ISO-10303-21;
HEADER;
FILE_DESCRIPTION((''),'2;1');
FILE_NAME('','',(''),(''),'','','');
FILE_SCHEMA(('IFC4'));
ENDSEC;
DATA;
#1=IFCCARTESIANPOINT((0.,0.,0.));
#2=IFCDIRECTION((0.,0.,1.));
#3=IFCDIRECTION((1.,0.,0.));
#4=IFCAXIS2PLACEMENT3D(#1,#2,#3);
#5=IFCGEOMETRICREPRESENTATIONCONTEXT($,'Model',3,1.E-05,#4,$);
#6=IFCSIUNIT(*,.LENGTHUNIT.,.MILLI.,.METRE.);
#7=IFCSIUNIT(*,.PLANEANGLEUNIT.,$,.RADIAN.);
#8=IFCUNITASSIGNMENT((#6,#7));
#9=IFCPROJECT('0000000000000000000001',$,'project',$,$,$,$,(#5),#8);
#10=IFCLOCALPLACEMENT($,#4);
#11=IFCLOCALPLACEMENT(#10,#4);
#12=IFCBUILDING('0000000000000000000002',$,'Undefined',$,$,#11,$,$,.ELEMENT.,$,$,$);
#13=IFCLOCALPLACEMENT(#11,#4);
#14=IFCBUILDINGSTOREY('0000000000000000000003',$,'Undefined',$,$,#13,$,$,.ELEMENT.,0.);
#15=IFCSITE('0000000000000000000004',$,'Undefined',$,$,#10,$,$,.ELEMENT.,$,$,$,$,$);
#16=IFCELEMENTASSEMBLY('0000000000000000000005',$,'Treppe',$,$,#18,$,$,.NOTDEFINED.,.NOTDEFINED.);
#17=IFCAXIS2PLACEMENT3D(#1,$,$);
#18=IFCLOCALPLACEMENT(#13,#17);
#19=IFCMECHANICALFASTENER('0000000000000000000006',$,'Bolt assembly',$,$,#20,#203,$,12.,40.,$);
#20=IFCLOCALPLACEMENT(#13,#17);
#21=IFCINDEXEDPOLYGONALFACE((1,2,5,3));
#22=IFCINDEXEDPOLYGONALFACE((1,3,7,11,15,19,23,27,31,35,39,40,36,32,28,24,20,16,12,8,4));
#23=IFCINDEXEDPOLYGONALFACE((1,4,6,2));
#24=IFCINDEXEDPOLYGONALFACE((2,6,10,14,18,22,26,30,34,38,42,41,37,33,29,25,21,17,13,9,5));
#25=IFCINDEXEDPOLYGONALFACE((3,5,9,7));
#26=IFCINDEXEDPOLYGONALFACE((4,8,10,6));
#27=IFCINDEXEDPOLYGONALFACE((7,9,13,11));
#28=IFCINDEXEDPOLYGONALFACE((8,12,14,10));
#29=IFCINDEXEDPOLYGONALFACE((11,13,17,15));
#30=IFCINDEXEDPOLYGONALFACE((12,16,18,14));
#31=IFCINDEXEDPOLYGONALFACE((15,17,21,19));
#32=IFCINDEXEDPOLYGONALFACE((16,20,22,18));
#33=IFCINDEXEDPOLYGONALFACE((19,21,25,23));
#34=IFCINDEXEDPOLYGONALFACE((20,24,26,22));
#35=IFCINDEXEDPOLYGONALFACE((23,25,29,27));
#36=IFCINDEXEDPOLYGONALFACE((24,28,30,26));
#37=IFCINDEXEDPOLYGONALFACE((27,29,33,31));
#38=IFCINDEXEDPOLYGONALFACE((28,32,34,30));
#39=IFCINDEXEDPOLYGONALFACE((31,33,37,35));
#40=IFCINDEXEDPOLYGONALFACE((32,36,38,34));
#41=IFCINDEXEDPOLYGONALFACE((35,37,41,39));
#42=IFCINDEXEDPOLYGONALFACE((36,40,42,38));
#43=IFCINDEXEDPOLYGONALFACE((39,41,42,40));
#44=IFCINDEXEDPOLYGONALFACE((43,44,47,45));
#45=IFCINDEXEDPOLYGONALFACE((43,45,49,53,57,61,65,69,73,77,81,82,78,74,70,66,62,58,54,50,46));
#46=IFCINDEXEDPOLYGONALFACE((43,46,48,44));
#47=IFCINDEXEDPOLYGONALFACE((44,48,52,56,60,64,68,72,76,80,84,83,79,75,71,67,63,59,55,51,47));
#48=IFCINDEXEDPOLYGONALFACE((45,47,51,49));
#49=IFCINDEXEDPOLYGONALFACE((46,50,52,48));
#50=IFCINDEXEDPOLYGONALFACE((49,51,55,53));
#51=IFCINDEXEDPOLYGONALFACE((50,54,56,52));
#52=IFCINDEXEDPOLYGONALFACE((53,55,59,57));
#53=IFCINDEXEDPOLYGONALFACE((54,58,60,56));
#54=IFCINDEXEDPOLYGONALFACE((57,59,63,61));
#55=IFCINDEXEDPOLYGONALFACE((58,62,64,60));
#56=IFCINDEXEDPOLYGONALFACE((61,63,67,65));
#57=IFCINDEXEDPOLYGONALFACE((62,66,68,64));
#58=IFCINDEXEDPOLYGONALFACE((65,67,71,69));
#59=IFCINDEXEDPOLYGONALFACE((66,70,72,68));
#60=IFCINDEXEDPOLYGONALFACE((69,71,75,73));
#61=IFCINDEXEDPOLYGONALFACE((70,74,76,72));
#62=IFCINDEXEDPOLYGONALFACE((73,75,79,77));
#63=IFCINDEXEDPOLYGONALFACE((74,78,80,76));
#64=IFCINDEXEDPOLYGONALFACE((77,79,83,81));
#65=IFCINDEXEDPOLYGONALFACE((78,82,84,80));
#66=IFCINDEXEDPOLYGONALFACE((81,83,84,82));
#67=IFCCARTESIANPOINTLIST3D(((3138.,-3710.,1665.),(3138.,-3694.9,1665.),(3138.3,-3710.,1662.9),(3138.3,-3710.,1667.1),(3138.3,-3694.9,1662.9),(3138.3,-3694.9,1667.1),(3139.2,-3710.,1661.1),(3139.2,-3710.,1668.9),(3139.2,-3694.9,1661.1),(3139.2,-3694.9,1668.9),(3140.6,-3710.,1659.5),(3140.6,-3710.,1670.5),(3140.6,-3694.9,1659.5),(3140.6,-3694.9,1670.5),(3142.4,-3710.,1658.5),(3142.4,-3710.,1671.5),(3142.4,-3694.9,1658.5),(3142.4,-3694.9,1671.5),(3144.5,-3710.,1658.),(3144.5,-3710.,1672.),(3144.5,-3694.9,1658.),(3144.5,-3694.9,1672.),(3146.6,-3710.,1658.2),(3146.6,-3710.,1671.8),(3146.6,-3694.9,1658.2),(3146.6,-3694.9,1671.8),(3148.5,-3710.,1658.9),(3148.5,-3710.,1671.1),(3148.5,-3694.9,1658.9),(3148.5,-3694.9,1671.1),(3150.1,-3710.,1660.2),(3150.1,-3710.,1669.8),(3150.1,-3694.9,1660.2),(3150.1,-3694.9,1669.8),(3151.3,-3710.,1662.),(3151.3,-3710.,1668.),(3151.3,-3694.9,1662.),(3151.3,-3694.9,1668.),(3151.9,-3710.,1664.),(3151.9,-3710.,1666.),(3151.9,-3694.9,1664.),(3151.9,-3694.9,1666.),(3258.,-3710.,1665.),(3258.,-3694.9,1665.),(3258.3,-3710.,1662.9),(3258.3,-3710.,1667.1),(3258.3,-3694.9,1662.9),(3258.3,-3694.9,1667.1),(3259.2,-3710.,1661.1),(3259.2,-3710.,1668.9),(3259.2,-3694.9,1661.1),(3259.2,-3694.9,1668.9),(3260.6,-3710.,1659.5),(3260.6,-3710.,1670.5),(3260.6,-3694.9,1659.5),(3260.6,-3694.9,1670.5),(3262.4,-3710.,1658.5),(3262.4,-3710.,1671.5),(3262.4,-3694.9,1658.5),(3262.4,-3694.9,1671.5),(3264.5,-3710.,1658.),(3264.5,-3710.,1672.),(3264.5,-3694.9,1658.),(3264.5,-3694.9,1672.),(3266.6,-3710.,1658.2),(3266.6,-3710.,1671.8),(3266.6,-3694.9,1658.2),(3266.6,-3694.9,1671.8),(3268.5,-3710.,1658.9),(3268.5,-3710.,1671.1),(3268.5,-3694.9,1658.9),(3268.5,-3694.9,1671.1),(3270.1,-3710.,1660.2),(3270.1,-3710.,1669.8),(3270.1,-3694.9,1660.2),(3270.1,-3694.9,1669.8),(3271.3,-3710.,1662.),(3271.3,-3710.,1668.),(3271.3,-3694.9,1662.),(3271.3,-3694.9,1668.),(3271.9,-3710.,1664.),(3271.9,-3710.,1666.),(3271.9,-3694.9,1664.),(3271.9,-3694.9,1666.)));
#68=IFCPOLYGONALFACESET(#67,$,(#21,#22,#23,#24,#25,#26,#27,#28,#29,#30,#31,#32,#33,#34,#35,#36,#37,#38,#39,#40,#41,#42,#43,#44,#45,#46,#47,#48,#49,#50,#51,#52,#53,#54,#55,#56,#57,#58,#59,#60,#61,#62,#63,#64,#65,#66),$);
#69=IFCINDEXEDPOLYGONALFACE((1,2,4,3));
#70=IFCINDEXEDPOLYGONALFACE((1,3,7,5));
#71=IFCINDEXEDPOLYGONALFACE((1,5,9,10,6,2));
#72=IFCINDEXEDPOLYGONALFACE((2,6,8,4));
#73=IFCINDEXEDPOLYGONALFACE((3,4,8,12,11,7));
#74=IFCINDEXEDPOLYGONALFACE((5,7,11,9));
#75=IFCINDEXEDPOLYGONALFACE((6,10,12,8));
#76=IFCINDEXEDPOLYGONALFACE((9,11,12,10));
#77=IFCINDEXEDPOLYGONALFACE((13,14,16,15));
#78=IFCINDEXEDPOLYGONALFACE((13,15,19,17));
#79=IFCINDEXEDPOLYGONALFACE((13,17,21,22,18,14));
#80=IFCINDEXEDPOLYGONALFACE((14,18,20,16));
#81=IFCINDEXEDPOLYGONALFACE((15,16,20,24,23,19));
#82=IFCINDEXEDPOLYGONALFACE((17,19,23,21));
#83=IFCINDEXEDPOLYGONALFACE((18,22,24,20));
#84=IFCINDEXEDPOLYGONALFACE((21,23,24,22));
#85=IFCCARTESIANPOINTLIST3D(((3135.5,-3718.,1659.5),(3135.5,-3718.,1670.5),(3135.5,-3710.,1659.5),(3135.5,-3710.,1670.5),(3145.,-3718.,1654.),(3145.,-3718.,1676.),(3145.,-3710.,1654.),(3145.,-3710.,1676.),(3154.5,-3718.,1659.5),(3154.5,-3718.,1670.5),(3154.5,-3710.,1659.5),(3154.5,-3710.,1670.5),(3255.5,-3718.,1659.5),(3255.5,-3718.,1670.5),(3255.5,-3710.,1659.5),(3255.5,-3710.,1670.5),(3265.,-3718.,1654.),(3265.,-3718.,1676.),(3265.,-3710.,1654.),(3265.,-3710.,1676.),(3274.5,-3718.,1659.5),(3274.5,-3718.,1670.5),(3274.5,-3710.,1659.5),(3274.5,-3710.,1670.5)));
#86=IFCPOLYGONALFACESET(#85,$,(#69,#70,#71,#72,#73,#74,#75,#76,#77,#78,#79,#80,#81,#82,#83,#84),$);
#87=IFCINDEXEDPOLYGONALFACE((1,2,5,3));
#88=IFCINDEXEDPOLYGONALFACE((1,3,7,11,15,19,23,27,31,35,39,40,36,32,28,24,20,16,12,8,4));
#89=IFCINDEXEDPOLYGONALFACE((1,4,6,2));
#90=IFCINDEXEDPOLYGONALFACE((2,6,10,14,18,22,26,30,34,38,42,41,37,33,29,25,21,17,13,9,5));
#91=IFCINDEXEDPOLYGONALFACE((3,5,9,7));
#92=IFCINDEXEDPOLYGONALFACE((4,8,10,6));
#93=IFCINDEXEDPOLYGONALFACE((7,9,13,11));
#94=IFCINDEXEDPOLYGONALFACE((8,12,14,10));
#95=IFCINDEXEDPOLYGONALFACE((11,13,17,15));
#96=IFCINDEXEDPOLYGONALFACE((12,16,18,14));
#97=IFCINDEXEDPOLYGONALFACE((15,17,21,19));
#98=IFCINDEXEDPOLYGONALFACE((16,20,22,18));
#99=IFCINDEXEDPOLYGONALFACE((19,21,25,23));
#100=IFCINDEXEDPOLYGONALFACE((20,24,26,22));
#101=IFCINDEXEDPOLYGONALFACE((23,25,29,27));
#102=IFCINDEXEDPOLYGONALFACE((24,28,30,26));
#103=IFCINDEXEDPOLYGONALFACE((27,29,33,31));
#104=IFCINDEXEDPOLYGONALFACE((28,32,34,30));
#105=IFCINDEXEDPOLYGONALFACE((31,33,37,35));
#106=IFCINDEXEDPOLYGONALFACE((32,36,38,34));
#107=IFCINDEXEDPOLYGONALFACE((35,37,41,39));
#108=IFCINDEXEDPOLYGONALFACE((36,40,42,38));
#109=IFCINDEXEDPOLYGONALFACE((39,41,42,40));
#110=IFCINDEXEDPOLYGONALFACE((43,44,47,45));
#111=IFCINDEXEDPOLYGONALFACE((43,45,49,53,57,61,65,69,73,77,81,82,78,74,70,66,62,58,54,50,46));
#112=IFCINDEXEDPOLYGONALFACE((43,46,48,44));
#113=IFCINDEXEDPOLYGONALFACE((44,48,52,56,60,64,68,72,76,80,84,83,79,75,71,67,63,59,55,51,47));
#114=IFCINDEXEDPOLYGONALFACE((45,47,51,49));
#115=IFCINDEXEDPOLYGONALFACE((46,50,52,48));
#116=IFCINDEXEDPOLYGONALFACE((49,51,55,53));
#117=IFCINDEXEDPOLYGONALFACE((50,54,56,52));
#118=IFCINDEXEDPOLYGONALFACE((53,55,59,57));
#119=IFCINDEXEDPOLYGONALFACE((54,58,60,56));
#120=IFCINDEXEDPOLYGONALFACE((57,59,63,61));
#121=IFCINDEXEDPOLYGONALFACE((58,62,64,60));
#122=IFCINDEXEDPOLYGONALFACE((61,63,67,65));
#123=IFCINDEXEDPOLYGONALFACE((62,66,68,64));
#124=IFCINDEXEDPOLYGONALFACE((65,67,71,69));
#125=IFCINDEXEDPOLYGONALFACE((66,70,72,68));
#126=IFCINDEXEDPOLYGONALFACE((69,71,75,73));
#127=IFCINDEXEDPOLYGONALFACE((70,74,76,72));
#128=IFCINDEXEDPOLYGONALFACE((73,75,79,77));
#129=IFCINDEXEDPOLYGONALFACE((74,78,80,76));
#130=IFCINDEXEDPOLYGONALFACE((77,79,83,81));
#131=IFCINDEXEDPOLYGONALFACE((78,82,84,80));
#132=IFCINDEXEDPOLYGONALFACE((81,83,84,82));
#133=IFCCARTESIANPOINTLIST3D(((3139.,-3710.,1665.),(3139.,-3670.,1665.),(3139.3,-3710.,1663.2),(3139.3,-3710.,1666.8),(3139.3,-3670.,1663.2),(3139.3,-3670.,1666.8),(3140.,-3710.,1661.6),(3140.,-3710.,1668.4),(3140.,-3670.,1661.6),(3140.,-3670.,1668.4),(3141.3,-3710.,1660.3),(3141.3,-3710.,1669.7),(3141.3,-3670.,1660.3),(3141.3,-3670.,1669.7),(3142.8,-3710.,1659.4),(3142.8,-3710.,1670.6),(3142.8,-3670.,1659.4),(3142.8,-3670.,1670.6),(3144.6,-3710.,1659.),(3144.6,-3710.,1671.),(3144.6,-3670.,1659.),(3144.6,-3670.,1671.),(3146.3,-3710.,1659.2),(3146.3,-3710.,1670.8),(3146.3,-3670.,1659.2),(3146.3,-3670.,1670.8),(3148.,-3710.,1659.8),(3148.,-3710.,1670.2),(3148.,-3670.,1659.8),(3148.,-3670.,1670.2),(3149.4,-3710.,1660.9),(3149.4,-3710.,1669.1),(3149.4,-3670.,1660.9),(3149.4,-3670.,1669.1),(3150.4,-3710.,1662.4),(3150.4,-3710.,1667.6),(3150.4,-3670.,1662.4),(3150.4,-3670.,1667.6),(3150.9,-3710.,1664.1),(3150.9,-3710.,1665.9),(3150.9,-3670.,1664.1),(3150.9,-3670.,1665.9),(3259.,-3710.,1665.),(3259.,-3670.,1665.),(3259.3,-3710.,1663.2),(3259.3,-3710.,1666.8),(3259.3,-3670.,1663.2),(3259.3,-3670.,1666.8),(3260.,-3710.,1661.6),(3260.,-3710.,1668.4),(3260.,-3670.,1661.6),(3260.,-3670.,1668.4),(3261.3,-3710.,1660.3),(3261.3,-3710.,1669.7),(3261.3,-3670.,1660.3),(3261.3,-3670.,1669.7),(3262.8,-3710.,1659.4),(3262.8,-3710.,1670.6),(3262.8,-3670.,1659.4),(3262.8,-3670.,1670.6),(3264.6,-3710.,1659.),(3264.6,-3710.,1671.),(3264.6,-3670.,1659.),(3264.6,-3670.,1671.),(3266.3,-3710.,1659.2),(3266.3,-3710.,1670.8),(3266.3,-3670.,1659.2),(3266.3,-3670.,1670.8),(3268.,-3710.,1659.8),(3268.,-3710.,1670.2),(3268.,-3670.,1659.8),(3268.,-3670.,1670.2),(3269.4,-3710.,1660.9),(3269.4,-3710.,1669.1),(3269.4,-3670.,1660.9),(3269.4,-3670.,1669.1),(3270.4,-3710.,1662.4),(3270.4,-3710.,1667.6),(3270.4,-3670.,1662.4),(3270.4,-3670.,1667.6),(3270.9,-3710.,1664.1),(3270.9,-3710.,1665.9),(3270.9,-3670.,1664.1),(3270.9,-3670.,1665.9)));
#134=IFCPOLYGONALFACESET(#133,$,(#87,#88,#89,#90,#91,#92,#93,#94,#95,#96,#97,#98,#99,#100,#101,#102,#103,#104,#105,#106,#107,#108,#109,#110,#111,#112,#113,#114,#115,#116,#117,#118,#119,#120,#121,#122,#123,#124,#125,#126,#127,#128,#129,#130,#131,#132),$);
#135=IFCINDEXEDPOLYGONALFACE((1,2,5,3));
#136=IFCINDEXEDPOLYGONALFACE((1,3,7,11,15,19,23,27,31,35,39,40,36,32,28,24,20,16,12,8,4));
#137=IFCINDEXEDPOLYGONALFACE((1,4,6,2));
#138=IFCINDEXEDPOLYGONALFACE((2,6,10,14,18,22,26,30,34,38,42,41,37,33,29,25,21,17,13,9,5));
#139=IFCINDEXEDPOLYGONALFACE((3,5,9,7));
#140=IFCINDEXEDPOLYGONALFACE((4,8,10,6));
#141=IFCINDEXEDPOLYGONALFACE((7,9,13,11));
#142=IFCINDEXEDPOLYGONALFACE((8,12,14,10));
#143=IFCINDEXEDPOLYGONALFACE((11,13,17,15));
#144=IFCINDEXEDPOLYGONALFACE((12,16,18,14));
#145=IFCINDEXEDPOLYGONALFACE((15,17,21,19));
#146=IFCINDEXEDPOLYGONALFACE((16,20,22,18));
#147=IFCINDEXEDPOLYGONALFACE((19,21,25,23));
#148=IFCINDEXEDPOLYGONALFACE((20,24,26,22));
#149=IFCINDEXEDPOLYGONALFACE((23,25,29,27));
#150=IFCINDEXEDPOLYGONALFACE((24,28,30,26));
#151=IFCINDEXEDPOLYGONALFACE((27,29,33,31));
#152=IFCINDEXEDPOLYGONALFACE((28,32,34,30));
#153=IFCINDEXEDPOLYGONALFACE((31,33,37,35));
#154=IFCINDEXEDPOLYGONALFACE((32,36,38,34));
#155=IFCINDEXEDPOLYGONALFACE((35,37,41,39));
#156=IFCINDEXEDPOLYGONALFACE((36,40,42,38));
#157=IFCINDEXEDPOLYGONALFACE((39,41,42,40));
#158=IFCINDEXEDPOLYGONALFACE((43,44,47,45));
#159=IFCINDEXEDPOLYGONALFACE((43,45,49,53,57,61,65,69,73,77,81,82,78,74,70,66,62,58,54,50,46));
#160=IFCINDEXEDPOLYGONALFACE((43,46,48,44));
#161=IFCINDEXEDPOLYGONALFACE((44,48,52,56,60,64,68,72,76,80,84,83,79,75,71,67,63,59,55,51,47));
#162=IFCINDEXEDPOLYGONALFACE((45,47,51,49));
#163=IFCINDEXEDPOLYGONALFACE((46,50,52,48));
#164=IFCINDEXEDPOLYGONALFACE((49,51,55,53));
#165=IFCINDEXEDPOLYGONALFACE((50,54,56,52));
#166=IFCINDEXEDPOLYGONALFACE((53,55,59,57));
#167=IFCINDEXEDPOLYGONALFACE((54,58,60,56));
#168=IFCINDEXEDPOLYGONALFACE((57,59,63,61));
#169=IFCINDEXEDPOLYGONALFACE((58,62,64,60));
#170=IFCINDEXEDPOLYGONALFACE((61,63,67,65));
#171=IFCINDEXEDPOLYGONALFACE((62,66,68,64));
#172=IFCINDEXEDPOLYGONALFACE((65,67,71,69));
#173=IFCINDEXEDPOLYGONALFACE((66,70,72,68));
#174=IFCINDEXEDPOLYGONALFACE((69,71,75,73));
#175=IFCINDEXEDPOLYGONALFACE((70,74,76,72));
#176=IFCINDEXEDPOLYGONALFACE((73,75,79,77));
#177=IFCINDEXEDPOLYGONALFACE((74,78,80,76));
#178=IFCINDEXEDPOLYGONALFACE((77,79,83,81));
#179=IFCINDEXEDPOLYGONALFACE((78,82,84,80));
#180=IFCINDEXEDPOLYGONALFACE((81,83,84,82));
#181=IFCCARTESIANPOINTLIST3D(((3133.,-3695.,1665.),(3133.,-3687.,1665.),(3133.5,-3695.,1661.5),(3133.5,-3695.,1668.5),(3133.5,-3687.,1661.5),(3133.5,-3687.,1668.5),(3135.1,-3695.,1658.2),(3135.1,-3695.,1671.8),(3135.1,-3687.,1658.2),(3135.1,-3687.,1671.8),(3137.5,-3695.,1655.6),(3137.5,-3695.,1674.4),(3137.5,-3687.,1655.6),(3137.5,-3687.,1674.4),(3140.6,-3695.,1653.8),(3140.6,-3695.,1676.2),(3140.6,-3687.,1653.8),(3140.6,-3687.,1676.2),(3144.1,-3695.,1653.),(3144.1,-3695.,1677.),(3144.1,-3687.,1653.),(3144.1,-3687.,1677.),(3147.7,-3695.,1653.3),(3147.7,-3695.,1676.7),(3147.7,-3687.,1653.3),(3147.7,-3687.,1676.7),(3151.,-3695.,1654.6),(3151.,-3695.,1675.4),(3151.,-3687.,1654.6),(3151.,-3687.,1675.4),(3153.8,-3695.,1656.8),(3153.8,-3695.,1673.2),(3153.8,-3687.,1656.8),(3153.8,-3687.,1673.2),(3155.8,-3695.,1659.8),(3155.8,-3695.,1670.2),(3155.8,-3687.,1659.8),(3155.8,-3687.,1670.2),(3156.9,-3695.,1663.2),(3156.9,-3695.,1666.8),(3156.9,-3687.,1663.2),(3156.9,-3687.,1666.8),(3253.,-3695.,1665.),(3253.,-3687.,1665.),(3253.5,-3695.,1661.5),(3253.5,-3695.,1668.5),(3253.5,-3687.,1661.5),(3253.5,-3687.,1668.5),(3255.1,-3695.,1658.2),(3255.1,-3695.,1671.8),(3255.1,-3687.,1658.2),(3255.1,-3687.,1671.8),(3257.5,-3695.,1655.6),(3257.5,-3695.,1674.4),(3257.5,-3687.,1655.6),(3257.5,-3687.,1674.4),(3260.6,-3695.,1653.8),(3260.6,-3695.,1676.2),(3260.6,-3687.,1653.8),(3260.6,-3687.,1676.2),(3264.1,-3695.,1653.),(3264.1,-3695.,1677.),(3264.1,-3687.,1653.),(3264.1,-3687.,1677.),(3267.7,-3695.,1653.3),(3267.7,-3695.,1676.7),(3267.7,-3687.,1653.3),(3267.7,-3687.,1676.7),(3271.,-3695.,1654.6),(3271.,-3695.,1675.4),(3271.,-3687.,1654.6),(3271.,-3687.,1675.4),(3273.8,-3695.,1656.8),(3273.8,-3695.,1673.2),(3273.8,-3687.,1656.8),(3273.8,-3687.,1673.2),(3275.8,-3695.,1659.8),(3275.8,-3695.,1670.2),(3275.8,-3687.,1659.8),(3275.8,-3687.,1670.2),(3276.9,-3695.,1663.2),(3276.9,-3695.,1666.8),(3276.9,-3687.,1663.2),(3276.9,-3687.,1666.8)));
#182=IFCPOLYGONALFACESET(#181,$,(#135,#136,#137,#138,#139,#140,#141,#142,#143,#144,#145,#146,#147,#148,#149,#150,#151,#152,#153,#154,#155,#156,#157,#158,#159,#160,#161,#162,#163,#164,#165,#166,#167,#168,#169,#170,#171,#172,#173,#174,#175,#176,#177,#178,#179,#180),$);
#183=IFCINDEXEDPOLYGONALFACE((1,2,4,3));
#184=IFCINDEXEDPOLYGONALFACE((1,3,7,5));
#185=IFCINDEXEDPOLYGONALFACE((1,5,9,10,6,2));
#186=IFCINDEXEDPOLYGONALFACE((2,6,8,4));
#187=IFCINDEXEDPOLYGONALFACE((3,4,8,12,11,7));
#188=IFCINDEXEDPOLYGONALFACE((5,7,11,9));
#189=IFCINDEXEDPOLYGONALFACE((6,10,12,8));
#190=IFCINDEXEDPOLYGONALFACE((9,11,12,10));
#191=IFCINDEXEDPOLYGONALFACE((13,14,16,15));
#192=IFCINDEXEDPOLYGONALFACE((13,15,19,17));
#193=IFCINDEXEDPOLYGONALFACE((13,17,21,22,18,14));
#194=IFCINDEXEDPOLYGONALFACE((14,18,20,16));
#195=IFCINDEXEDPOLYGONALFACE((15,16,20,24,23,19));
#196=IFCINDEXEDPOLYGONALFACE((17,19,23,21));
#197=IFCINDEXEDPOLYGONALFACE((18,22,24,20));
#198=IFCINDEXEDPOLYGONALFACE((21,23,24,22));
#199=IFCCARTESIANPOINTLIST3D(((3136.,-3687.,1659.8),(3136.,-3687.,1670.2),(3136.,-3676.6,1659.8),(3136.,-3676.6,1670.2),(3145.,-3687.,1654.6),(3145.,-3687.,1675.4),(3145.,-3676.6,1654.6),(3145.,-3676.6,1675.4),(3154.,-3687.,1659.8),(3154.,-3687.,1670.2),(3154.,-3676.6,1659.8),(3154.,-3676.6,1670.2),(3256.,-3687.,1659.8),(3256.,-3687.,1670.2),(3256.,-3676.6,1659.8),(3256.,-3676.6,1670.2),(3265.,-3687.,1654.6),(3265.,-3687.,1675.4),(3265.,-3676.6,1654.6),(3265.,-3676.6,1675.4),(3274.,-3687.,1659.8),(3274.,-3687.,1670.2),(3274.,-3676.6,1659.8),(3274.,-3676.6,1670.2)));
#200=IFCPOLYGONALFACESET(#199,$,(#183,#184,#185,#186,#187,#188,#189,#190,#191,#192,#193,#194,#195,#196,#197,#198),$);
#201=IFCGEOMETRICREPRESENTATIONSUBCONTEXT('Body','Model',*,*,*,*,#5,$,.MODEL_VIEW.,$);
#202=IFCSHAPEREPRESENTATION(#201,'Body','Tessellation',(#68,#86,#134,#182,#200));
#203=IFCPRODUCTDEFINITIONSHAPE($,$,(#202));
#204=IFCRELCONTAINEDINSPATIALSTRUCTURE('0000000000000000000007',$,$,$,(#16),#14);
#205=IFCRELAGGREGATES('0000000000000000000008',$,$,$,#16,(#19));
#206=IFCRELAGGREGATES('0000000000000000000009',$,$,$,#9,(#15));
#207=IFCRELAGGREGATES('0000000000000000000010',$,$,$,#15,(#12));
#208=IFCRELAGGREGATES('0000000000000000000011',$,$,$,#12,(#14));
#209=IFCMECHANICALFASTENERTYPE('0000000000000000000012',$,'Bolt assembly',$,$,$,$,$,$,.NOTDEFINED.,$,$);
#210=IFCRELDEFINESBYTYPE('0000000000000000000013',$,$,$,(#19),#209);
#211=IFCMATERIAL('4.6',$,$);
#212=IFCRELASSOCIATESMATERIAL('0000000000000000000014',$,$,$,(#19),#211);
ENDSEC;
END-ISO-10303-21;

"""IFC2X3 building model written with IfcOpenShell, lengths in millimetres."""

from ifc_helpers import new_model, si_unit, frame, origin_with_axes, origin_2d_with_axis, place, context, subcontext, project, spatial, polyline, circle, outline, extrude, source, transform, mapped, material, type_object, element, aggregate, save


model = new_model("IFC2X3")

# Units and contexts
model_context = context("Model", 3, precision=1e-05, world=origin_with_axes())
body_context = subcontext(model_context, "Body", "Model", "MODEL_VIEW")
ifc_project = project(units=[si_unit("LENGTHUNIT", "METRE", prefix="MILLI"), si_unit("PLANEANGLEUNIT", "RADIAN")], contexts=[model_context])

# Site, building, storey
site_placement = place(None, origin_with_axes())
site = spatial("IfcSite", under=ifc_project, at=site_placement, Name="Undefined", CompositionType="ELEMENT")
building_placement = place(site_placement, origin_with_axes())
building = spatial("IfcBuilding", under=site, at=building_placement, Name="Undefined", CompositionType="ELEMENT")
storey_placement = place(building_placement, origin_with_axes())
storey = spatial("IfcBuildingStorey", under=building, at=storey_placement, Name="Undefined", CompositionType="ELEMENT", Elevation=0.0)

# Element assembly, mechanical fastener
assembly_1_placement = place(storey_placement, origin_with_axes())
assembly_1 = element("IfcElementAssembly", 1, at=assembly_1_placement, inside=storey, Name="Treppe", AssemblyPlace="NOTDEFINED", PredefinedType="NOTDEFINED")
ifc_material_1 = material(Name="4.6")
mechanical_fastener_type = type_object("IfcMechanicalFastenerType", Name="Bolt assembly")
shared_shape_1 = source(origin_with_axes(), body_context, "Body", "SweptSolid", [
    extrude(circle(Radius=7.0, at=origin_2d_with_axis()), frame((0.0, 0.0, 0.0), z_axis=(0.0, 1.0, 0.0), x_axis=(1.0, 0.0, 0.0)), (0.0, 0.0, 1.0), 15.1),
    extrude(outline(polyline([(9.5, -5.5), (9.5, 5.5), (0.0, 11.0), (-9.5, 5.5), (-9.5, -5.5), (0.0, -11.0), (9.5, -5.5)])), frame((0.0, -8.0, 0.0), z_axis=(0.0, 1.0, 0.0), x_axis=(1.0, 0.0, 0.0)), (0.0, 0.0, 1.0), 8.0),
    extrude(circle(Radius=6.0, at=origin_2d_with_axis()), frame((0.0, 0.0, 0.0), z_axis=(0.0, 1.0, 0.0), x_axis=(1.0, 0.0, 0.0)), (0.0, 0.0, 1.0), 40.0),
    extrude(circle(Radius=12.0, at=origin_2d_with_axis()), frame((0.0, 15.0, 0.0), z_axis=(0.0, 1.0, 0.0), x_axis=(1.0, 0.0, 0.0)), (0.0, 0.0, 1.0), 8.0),
    extrude(outline(polyline([(9.0, -5.2), (9.0, 5.2), (0.0, 10.4), (-9.0, 5.2), (-9.0, -5.2), (0.0, -10.4), (9.0, -5.2)])), frame((0.0, 23.0, 0.0), z_axis=(0.0, 1.0, 0.0), x_axis=(1.0, 0.0, 0.0)), (0.0, 0.0, 1.0), 10.4),
])
mechanical_fastener_1_placement = place(assembly_1_placement, frame((3265.0, -3710.0, 1665.0), z_axis=(0.0, 0.0, -1.0), x_axis=(-1.0, 0.0, 0.0)))
mechanical_fastener_1 = element("IfcMechanicalFastener", 2, at=mechanical_fastener_1_placement, type_object=mechanical_fastener_type, material=ifc_material_1, Name="Bolt assembly", NominalDiameter=12.0, NominalLength=40.0, context=body_context, shape_type="MappedRepresentation", body=[
    mapped(shared_shape_1, transform((0.0, 0.0, 0.0))),
    mapped(shared_shape_1, transform((120.0, 0.0, 0.0))),
])
aggregate(assembly_1, [mechanical_fastener_1])

save(model, "model.ifc")
